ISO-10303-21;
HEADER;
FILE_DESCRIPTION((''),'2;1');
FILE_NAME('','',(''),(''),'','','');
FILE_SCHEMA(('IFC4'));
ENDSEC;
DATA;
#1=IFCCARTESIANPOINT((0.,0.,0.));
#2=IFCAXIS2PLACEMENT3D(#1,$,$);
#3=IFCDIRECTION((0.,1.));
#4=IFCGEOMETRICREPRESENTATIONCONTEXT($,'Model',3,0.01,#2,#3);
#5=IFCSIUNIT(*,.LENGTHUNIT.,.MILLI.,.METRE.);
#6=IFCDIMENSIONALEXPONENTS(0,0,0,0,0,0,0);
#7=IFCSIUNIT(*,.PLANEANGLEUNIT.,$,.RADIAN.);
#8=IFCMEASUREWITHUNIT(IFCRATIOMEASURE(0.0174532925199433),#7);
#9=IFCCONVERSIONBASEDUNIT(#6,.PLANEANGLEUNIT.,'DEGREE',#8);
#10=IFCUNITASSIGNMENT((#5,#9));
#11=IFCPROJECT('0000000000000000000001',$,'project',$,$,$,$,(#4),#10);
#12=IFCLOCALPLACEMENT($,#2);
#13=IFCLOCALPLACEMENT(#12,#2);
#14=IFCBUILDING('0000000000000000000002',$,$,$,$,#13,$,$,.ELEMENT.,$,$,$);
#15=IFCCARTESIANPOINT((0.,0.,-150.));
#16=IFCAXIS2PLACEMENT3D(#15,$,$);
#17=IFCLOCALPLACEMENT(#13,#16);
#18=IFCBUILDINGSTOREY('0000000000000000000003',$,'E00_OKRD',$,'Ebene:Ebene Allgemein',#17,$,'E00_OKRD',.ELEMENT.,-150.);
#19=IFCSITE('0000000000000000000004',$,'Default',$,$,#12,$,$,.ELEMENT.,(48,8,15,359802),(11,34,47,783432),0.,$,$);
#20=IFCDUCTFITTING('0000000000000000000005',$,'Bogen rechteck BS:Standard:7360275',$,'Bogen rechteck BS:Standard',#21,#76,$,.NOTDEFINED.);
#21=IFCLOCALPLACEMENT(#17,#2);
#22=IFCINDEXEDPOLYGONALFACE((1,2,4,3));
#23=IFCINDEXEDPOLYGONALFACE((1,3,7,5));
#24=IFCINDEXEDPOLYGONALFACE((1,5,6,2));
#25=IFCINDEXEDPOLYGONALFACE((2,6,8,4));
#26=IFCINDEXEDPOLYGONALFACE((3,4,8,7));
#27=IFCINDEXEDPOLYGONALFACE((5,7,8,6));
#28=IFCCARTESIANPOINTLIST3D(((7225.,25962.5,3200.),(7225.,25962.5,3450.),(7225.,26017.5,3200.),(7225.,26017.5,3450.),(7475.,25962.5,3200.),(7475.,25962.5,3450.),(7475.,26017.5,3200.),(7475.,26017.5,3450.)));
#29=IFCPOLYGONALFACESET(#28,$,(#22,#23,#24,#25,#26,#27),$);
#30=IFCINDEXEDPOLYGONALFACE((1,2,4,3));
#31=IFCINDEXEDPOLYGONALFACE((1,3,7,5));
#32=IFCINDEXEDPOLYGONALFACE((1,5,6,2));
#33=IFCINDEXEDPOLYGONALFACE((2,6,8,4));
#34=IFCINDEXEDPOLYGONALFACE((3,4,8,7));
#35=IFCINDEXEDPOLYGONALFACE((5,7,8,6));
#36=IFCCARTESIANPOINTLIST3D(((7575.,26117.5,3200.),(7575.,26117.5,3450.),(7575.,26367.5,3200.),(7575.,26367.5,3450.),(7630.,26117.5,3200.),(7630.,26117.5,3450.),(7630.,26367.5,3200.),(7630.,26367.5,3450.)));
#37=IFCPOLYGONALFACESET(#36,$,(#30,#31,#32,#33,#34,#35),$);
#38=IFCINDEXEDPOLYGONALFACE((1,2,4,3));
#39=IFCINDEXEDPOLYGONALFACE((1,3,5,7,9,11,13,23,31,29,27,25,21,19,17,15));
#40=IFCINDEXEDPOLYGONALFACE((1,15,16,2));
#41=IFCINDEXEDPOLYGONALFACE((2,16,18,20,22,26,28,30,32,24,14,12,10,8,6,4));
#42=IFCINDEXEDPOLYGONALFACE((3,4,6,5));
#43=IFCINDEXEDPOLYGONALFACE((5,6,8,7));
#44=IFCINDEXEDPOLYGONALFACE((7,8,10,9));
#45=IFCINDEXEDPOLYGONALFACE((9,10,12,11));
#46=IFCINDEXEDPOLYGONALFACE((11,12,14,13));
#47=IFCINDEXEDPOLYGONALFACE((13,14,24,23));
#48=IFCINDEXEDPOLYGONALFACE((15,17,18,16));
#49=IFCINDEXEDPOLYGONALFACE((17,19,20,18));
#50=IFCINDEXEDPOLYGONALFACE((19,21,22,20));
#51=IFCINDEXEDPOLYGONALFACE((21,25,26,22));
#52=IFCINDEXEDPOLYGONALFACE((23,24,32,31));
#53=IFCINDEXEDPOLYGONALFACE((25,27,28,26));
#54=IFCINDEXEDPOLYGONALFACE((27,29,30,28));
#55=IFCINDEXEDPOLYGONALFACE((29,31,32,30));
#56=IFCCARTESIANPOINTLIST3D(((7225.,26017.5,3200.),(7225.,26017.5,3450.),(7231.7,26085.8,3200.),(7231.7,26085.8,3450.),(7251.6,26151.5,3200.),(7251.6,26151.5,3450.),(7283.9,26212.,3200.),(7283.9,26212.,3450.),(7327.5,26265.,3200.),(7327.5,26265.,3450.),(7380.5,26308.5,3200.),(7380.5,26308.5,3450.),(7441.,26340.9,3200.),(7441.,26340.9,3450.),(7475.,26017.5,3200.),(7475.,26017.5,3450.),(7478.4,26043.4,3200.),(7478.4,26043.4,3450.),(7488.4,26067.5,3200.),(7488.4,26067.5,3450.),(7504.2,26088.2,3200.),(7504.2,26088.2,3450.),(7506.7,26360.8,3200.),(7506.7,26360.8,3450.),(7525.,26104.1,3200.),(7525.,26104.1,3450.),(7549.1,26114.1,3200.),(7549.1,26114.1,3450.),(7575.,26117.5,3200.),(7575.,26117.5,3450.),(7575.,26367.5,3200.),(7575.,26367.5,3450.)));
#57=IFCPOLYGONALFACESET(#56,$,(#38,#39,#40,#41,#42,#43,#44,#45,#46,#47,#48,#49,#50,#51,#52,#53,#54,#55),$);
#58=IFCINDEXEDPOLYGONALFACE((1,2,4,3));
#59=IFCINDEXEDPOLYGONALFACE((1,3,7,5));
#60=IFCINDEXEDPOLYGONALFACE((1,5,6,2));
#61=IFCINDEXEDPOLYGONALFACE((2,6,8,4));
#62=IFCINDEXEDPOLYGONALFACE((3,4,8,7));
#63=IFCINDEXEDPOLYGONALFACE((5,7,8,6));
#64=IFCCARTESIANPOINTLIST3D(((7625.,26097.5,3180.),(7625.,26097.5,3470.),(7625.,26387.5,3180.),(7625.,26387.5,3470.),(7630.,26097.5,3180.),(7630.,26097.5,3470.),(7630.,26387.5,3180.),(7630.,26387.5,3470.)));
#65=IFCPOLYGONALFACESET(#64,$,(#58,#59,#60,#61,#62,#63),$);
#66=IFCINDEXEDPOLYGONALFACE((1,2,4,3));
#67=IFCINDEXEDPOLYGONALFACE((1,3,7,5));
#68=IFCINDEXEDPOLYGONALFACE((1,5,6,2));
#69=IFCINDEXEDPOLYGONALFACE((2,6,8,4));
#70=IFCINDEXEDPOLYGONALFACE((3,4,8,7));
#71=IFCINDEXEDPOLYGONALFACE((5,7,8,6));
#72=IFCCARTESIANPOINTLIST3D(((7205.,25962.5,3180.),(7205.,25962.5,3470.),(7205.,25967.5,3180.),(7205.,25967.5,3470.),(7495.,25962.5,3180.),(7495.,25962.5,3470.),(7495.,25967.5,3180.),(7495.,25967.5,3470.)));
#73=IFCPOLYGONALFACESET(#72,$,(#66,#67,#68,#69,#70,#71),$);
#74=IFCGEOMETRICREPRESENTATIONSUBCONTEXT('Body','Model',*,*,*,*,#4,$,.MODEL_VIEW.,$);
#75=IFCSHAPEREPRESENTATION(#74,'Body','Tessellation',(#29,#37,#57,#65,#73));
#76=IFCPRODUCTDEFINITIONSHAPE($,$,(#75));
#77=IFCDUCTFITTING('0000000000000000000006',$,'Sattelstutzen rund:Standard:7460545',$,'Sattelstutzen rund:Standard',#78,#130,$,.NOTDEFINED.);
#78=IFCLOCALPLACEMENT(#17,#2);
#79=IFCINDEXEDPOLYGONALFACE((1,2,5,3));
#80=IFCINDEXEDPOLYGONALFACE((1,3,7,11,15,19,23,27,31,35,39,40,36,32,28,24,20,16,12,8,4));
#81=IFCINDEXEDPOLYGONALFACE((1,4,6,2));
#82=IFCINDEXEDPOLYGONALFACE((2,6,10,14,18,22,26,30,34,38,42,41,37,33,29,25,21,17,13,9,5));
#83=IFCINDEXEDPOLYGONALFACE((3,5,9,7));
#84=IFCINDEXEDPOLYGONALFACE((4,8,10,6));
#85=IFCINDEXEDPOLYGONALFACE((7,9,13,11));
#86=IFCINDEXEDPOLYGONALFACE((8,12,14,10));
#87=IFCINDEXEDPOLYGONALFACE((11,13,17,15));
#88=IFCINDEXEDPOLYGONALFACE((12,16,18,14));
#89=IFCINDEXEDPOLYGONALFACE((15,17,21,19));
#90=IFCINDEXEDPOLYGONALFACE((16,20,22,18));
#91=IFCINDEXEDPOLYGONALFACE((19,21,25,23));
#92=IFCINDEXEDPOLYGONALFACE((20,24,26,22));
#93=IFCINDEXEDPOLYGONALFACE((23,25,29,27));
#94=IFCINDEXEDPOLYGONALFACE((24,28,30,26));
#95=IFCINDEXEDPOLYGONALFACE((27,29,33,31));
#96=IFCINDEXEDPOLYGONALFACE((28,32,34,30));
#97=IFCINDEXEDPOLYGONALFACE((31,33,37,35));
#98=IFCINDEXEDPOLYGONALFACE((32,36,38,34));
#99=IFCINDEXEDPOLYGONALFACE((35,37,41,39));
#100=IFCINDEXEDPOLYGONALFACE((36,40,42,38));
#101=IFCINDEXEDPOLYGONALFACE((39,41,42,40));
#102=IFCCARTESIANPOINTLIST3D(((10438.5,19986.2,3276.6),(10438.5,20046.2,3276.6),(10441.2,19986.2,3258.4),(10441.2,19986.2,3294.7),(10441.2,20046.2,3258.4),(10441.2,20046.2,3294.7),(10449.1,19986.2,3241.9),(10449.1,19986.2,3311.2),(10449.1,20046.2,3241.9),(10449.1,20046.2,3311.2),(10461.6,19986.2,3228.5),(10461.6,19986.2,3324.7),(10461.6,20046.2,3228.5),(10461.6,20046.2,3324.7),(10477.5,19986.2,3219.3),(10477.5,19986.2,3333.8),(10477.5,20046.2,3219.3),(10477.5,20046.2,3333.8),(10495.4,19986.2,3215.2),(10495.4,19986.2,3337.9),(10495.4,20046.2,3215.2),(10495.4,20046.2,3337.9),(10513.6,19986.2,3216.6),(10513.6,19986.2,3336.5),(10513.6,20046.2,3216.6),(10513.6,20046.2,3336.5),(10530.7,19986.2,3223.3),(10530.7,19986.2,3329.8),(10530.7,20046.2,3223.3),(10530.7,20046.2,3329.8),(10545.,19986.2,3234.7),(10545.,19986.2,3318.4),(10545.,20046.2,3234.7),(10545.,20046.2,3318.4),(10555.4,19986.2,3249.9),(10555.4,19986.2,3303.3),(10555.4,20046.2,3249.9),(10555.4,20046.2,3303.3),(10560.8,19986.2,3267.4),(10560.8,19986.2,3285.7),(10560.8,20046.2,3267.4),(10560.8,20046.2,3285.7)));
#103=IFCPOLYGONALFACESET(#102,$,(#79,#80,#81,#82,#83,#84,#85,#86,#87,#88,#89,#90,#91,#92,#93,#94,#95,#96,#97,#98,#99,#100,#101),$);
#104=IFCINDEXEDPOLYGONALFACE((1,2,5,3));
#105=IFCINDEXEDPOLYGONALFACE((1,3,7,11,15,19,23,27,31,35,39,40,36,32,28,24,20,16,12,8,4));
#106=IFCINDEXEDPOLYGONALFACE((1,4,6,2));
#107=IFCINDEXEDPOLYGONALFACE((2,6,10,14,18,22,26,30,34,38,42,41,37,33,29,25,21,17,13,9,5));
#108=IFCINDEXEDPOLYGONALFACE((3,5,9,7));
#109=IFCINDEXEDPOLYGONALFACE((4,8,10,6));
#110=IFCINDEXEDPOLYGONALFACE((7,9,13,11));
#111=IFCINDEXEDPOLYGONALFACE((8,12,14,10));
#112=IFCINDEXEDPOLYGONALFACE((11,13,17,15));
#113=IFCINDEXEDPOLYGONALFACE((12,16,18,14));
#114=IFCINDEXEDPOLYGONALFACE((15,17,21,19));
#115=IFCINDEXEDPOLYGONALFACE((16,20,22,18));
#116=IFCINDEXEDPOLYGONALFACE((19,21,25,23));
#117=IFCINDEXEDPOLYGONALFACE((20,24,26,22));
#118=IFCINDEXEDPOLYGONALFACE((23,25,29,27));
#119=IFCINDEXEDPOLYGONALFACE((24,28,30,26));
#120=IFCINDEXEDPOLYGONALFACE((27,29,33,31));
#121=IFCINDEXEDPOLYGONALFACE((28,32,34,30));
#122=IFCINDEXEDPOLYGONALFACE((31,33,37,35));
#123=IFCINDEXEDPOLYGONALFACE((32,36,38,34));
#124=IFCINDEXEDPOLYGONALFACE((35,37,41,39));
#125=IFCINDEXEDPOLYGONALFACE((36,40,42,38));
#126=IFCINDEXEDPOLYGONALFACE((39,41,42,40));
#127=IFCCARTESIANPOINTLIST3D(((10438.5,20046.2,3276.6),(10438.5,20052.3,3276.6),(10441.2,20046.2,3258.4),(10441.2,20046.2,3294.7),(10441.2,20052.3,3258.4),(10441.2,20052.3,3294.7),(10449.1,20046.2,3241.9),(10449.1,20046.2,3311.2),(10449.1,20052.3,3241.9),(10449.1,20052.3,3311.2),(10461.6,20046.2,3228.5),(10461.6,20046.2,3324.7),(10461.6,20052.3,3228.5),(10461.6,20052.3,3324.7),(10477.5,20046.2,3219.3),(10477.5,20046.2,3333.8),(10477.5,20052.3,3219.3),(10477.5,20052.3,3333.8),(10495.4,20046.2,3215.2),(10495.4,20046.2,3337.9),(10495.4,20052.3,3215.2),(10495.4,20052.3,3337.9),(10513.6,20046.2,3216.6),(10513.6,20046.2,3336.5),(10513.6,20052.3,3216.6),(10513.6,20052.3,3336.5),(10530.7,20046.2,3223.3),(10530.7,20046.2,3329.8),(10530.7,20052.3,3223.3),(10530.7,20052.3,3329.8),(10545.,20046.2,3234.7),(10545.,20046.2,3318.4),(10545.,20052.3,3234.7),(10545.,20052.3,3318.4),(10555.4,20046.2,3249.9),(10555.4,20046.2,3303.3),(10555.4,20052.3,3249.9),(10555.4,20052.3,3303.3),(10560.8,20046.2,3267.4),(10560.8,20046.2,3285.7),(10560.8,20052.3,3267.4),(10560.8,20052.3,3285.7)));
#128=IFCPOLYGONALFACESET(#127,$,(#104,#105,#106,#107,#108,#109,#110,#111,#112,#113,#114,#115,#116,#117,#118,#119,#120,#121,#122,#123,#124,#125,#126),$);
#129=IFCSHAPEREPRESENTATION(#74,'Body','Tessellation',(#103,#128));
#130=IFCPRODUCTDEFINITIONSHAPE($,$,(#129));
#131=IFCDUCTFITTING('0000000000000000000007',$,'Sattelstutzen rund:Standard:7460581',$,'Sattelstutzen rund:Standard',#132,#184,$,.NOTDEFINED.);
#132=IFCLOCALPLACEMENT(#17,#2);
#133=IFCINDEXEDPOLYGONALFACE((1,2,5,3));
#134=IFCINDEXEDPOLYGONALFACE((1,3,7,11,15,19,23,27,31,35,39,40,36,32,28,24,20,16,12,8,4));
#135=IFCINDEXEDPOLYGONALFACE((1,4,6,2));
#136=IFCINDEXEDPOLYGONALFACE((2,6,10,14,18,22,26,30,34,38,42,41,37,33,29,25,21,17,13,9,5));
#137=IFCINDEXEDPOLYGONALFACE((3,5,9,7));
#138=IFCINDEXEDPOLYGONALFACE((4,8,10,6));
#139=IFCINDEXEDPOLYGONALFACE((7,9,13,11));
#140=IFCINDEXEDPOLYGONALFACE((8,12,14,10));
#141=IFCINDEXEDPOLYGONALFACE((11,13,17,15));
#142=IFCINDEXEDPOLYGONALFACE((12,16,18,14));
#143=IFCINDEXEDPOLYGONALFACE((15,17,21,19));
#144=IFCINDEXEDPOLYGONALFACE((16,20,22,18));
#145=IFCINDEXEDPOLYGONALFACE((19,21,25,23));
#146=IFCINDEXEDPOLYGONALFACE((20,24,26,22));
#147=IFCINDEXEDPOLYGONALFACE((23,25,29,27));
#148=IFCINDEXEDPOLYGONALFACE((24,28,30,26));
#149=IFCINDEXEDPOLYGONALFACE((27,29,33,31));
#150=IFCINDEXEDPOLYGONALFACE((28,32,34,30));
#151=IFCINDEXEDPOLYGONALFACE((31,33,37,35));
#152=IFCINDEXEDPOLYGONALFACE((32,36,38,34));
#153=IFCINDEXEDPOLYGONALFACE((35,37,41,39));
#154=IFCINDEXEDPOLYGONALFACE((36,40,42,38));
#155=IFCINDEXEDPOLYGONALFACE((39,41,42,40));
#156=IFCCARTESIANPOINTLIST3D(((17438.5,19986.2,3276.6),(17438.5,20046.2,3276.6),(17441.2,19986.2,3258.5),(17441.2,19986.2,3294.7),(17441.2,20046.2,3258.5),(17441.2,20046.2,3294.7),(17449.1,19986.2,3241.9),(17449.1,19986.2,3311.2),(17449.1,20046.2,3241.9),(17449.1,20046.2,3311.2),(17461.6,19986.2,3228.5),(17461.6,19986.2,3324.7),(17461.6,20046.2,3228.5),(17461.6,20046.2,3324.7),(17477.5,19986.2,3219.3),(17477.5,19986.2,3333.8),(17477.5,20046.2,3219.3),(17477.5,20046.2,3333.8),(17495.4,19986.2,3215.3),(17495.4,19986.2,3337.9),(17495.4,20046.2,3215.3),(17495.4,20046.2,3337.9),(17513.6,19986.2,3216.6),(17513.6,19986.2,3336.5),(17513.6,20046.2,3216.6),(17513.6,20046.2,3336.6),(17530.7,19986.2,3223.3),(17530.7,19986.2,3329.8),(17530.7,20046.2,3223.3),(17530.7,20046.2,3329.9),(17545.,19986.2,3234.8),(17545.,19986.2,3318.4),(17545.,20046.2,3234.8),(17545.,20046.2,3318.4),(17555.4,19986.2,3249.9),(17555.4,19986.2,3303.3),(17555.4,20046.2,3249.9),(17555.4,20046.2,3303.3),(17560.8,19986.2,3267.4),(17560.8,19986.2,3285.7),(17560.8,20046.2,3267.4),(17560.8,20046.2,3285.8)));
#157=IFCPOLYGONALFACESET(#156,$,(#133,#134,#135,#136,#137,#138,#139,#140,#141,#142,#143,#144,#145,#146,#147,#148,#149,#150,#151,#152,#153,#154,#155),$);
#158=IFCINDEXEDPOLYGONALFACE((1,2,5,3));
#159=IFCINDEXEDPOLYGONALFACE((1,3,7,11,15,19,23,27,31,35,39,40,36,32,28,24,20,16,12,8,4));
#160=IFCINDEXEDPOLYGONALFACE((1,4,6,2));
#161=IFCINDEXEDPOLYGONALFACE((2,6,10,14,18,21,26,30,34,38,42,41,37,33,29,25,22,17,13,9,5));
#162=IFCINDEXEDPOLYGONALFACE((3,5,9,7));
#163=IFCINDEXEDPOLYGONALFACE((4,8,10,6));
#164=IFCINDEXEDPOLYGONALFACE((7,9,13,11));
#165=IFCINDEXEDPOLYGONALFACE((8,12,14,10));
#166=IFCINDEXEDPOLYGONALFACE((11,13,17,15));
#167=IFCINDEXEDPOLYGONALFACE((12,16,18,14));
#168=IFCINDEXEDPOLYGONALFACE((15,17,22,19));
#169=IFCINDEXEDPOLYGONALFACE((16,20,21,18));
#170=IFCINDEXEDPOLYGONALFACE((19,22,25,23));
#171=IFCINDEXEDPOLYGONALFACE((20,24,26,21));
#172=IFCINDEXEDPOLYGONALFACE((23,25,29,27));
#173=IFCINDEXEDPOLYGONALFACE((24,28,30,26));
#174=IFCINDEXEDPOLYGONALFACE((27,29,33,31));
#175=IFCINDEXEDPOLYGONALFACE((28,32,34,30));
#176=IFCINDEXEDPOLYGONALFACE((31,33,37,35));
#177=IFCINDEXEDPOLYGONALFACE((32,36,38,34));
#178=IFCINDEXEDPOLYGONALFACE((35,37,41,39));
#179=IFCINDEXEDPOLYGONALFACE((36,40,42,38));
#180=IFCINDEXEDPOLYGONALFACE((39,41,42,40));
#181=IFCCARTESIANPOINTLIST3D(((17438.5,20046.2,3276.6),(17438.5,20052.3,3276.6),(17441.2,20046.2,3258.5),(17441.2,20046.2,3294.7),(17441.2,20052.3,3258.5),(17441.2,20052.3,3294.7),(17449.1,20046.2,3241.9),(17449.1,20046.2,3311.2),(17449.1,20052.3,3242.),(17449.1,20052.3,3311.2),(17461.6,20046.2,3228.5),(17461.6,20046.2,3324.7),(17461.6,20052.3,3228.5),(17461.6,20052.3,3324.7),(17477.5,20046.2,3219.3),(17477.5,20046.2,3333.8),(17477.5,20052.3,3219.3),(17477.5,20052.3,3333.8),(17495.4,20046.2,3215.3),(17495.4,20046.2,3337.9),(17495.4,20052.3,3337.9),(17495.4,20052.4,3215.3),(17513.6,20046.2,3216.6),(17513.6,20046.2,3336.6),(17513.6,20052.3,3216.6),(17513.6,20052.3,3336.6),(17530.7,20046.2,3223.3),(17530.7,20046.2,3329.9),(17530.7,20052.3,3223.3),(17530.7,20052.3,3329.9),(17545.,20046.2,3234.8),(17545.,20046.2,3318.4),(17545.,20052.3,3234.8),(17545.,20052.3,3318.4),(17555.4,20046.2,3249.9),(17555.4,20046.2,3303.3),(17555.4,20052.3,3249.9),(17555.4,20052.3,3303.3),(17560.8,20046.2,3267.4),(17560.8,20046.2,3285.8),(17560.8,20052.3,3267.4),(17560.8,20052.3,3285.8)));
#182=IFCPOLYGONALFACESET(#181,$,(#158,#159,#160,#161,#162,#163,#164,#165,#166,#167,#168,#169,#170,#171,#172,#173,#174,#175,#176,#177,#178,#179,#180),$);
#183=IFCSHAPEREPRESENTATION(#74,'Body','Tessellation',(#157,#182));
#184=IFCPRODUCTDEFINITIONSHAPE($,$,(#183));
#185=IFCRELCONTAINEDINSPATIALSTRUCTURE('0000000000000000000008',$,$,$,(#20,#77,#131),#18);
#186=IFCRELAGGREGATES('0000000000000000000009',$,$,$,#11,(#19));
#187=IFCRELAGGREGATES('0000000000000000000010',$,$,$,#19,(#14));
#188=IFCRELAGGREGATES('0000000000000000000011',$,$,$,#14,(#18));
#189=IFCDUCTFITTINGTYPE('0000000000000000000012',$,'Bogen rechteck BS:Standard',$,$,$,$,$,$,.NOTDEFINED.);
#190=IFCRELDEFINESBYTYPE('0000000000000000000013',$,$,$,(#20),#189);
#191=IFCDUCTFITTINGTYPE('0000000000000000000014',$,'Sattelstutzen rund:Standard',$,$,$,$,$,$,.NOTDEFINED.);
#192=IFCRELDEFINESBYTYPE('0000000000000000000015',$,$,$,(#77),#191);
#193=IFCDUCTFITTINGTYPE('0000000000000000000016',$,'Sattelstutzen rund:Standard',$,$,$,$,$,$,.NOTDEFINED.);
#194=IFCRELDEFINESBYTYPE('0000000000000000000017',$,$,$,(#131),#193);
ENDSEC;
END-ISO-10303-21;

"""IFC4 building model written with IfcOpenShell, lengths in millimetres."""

from ifc_helpers import new_model, entity, si_unit, converted_unit, direction, frame, frame_2d, origin, origin_2d_with_axis, place, context, subcontext, project, spatial, polyline, circle_curve, parameter, trimmed, segment, composite_curve, rectangle, circle, outline, extrude, source, transform, mapped, type_object, type_shapes, element, save


model = new_model("IFC4")

# Units and contexts
model_context = context("Model", 3, precision=0.01, world=origin(), true_north=direction((0.0, 1.0)))
body_context = subcontext(model_context, "Body", "Model", "MODEL_VIEW")
ifc_project = project(units=[si_unit("LENGTHUNIT", "METRE", prefix="MILLI"), converted_unit("PLANEANGLEUNIT", "DEGREE", entity("IfcRatioMeasure", 0.0174532925199433), si_unit("PLANEANGLEUNIT", "RADIAN"), dimensions=[0, 0, 0, 0, 0, 0, 0])], contexts=[model_context])

# Site, building, storey
site_placement = place(None, origin())
site = spatial("IfcSite", under=ifc_project, at=site_placement, Name="Default", CompositionType="ELEMENT", RefLatitude=(48, 8, 15, 359802), RefLongitude=(11, 34, 47, 783432), RefElevation=0.0)
building_placement = place(site_placement, origin())
building = spatial("IfcBuilding", under=site, at=building_placement, CompositionType="ELEMENT")
storey_placement = place(building_placement, frame((0.0, 0.0, -150.0)))
storey = spatial("IfcBuildingStorey", under=building, at=storey_placement, Name="E00_OKRD", ObjectType="Ebene:Ebene Allgemein", LongName="E00_OKRD", CompositionType="ELEMENT", Elevation=-150.0)

# Duct fittings
duct_fitting_type_1 = type_object("IfcDuctFittingType", Name="Bogen rechteck BS:Standard", PredefinedType="NOTDEFINED")
shared_shape_1 = source(origin(), body_context, "Body", "SweptSolid", [
    extrude(rectangle(XDim=55.0, YDim=250.0, at=origin_2d_with_axis()), frame((0.0, 252.5, -125.0), z_axis=(0.0, 0.0, 1.0), x_axis=(0.0, 1.0, 0.0)), (0.0, 0.0, 1.0), 250.0),
    extrude(rectangle(XDim=250.0, YDim=55.0, at=frame_2d((0.0, 0.0), x_axis=(1.0, 0.0))), frame((-252.5, 0.0, -125.0), z_axis=(0.0, 0.0, 1.0), x_axis=(0.0, -1.0, 0.0)), (0.0, 0.0, 1.0), 250.0),
    extrude(outline(composite_curve([segment(polyline([(-237.5, -112.5), (12.5, -112.5)]), True, "CONTINUOUS"), segment(trimmed(circle_curve(frame_2d((112.5, -112.5), x_axis=(0.0, 1.0)), 100.0), [parameter(0.0)], [parameter(90.0)], True, "PARAMETER"), False, "CONTINUOUS"), segment(polyline([(112.5, -12.5), (112.5, 237.5)]), True, "CONTINUOUS"), segment(trimmed(circle_curve(frame_2d((112.5, -112.5), x_axis=(0.0, 1.0)), 350.0), [parameter(0.0)], [parameter(90.0)], True, "PARAMETER"), True, "CONTINUOUS")], self_intersect=False)), frame((-112.5, 112.5, -125.0), z_axis=(0.0, 0.0, 1.0), x_axis=(-1.0, 0.0, 0.0)), (0.0, 0.0, 1.0), 250.0),
    extrude(rectangle(XDim=5.0, YDim=290.0, at=frame_2d((0.0, 0.0), x_axis=(1.0, 0.0))), frame((-277.5, 0.0, -145.0)), (0.0, 0.0, 1.0), 290.0),
    extrude(rectangle(XDim=5.0, YDim=290.0, at=origin_2d_with_axis()), frame((0.0, 277.5, -145.0), z_axis=(0.0, 0.0, 1.0), x_axis=(0.0, 1.0, 0.0)), (0.0, 0.0, 1.0), 290.0),
])
type_shapes(duct_fitting_type_1, [shared_shape_1])
duct_fitting_1_placement = place(storey_placement, frame((7350.0, 26242.5, 3325.0), z_axis=(0.0, 0.0, 1.0), x_axis=(-1.0, 0.0, 0.0)))
element("IfcDuctFitting", 1, at=duct_fitting_1_placement, inside=storey, type_object=duct_fitting_type_1, Name="Bogen rechteck BS:Standard:7360275", ObjectType="Bogen rechteck BS:Standard", PredefinedType="NOTDEFINED", context=body_context, shape_type="MappedRepresentation", body=[
    mapped(shared_shape_1, transform((0.0, 0.0, 0.0), scale=1.0)),
])
duct_fitting_type_2 = type_object("IfcDuctFittingType", Name="Sattelstutzen rund:Standard", PredefinedType="NOTDEFINED")
shared_shape_2 = source(origin(), body_context, "Body", "SweptSolid", [
    extrude(circle(Radius=61.5, at=frame_2d((0.0, 0.0), x_axis=(1.0, 0.0))), frame((0.0, 0.0, 0.0), z_axis=(1.0, 0.0, 0.0), x_axis=(0.0, 1.0, 0.0)), (0.0, 0.0, 1.0), 60.0),
    extrude(circle(Radius=61.5, at=frame_2d((0.0, 0.0), x_axis=(1.0, 0.0))), frame((-6.1, 0.0, 0.0), z_axis=(1.0, 0.0, 0.0), x_axis=(0.0, 1.0, 0.0)), (0.0, 0.0, 1.0), 6.1),
])
type_shapes(duct_fitting_type_2, [shared_shape_2])
duct_fitting_2_placement = place(storey_placement, frame((10500.0, 20046.2, 3276.6), z_axis=(0.0, 0.0, -1.0), x_axis=(0.0, -1.0, 0.0)))
element("IfcDuctFitting", 2, at=duct_fitting_2_placement, inside=storey, type_object=duct_fitting_type_2, Name="Sattelstutzen rund:Standard:7460545", ObjectType="Sattelstutzen rund:Standard", PredefinedType="NOTDEFINED", context=body_context, shape_type="MappedRepresentation", body=[
    mapped(shared_shape_2, transform((0.0, 0.0, 0.0), scale=1.0)),
])
duct_fitting_type_3 = type_object("IfcDuctFittingType", Name="Sattelstutzen rund:Standard", PredefinedType="NOTDEFINED")
shared_shape_3 = source(origin(), body_context, "Body", "SweptSolid", [
    extrude(circle(Radius=61.5, at=frame_2d((0.0, 0.0), x_axis=(1.0, 0.0))), frame((0.0, 0.0, 0.0), z_axis=(1.0, 0.0, 0.0), x_axis=(0.0, 1.0, 0.0)), (0.0, 0.0, 1.0), 60.0),
    extrude(circle(Radius=61.5, at=frame_2d((0.0, 0.0), x_axis=(1.0, 0.0))), frame((-6.1, 0.0, 0.0), z_axis=(1.0, 0.0, 0.0), x_axis=(0.0, 1.0, 0.0)), (0.0, 0.0, 1.0), 6.1),
])
type_shapes(duct_fitting_type_3, [shared_shape_3])
duct_fitting_3_placement = place(storey_placement, frame((17500.0, 20046.2, 3276.6), z_axis=(0.0, 0.000188, -1.0), x_axis=(0.0, -1.0, -0.000188)))
element("IfcDuctFitting", 3, at=duct_fitting_3_placement, inside=storey, type_object=duct_fitting_type_3, Name="Sattelstutzen rund:Standard:7460581", ObjectType="Sattelstutzen rund:Standard", PredefinedType="NOTDEFINED", context=body_context, shape_type="MappedRepresentation", body=[
    mapped(shared_shape_3, transform((0.0, 0.0, 0.0), scale=1.0)),
])

save(model, "model.ifc")
